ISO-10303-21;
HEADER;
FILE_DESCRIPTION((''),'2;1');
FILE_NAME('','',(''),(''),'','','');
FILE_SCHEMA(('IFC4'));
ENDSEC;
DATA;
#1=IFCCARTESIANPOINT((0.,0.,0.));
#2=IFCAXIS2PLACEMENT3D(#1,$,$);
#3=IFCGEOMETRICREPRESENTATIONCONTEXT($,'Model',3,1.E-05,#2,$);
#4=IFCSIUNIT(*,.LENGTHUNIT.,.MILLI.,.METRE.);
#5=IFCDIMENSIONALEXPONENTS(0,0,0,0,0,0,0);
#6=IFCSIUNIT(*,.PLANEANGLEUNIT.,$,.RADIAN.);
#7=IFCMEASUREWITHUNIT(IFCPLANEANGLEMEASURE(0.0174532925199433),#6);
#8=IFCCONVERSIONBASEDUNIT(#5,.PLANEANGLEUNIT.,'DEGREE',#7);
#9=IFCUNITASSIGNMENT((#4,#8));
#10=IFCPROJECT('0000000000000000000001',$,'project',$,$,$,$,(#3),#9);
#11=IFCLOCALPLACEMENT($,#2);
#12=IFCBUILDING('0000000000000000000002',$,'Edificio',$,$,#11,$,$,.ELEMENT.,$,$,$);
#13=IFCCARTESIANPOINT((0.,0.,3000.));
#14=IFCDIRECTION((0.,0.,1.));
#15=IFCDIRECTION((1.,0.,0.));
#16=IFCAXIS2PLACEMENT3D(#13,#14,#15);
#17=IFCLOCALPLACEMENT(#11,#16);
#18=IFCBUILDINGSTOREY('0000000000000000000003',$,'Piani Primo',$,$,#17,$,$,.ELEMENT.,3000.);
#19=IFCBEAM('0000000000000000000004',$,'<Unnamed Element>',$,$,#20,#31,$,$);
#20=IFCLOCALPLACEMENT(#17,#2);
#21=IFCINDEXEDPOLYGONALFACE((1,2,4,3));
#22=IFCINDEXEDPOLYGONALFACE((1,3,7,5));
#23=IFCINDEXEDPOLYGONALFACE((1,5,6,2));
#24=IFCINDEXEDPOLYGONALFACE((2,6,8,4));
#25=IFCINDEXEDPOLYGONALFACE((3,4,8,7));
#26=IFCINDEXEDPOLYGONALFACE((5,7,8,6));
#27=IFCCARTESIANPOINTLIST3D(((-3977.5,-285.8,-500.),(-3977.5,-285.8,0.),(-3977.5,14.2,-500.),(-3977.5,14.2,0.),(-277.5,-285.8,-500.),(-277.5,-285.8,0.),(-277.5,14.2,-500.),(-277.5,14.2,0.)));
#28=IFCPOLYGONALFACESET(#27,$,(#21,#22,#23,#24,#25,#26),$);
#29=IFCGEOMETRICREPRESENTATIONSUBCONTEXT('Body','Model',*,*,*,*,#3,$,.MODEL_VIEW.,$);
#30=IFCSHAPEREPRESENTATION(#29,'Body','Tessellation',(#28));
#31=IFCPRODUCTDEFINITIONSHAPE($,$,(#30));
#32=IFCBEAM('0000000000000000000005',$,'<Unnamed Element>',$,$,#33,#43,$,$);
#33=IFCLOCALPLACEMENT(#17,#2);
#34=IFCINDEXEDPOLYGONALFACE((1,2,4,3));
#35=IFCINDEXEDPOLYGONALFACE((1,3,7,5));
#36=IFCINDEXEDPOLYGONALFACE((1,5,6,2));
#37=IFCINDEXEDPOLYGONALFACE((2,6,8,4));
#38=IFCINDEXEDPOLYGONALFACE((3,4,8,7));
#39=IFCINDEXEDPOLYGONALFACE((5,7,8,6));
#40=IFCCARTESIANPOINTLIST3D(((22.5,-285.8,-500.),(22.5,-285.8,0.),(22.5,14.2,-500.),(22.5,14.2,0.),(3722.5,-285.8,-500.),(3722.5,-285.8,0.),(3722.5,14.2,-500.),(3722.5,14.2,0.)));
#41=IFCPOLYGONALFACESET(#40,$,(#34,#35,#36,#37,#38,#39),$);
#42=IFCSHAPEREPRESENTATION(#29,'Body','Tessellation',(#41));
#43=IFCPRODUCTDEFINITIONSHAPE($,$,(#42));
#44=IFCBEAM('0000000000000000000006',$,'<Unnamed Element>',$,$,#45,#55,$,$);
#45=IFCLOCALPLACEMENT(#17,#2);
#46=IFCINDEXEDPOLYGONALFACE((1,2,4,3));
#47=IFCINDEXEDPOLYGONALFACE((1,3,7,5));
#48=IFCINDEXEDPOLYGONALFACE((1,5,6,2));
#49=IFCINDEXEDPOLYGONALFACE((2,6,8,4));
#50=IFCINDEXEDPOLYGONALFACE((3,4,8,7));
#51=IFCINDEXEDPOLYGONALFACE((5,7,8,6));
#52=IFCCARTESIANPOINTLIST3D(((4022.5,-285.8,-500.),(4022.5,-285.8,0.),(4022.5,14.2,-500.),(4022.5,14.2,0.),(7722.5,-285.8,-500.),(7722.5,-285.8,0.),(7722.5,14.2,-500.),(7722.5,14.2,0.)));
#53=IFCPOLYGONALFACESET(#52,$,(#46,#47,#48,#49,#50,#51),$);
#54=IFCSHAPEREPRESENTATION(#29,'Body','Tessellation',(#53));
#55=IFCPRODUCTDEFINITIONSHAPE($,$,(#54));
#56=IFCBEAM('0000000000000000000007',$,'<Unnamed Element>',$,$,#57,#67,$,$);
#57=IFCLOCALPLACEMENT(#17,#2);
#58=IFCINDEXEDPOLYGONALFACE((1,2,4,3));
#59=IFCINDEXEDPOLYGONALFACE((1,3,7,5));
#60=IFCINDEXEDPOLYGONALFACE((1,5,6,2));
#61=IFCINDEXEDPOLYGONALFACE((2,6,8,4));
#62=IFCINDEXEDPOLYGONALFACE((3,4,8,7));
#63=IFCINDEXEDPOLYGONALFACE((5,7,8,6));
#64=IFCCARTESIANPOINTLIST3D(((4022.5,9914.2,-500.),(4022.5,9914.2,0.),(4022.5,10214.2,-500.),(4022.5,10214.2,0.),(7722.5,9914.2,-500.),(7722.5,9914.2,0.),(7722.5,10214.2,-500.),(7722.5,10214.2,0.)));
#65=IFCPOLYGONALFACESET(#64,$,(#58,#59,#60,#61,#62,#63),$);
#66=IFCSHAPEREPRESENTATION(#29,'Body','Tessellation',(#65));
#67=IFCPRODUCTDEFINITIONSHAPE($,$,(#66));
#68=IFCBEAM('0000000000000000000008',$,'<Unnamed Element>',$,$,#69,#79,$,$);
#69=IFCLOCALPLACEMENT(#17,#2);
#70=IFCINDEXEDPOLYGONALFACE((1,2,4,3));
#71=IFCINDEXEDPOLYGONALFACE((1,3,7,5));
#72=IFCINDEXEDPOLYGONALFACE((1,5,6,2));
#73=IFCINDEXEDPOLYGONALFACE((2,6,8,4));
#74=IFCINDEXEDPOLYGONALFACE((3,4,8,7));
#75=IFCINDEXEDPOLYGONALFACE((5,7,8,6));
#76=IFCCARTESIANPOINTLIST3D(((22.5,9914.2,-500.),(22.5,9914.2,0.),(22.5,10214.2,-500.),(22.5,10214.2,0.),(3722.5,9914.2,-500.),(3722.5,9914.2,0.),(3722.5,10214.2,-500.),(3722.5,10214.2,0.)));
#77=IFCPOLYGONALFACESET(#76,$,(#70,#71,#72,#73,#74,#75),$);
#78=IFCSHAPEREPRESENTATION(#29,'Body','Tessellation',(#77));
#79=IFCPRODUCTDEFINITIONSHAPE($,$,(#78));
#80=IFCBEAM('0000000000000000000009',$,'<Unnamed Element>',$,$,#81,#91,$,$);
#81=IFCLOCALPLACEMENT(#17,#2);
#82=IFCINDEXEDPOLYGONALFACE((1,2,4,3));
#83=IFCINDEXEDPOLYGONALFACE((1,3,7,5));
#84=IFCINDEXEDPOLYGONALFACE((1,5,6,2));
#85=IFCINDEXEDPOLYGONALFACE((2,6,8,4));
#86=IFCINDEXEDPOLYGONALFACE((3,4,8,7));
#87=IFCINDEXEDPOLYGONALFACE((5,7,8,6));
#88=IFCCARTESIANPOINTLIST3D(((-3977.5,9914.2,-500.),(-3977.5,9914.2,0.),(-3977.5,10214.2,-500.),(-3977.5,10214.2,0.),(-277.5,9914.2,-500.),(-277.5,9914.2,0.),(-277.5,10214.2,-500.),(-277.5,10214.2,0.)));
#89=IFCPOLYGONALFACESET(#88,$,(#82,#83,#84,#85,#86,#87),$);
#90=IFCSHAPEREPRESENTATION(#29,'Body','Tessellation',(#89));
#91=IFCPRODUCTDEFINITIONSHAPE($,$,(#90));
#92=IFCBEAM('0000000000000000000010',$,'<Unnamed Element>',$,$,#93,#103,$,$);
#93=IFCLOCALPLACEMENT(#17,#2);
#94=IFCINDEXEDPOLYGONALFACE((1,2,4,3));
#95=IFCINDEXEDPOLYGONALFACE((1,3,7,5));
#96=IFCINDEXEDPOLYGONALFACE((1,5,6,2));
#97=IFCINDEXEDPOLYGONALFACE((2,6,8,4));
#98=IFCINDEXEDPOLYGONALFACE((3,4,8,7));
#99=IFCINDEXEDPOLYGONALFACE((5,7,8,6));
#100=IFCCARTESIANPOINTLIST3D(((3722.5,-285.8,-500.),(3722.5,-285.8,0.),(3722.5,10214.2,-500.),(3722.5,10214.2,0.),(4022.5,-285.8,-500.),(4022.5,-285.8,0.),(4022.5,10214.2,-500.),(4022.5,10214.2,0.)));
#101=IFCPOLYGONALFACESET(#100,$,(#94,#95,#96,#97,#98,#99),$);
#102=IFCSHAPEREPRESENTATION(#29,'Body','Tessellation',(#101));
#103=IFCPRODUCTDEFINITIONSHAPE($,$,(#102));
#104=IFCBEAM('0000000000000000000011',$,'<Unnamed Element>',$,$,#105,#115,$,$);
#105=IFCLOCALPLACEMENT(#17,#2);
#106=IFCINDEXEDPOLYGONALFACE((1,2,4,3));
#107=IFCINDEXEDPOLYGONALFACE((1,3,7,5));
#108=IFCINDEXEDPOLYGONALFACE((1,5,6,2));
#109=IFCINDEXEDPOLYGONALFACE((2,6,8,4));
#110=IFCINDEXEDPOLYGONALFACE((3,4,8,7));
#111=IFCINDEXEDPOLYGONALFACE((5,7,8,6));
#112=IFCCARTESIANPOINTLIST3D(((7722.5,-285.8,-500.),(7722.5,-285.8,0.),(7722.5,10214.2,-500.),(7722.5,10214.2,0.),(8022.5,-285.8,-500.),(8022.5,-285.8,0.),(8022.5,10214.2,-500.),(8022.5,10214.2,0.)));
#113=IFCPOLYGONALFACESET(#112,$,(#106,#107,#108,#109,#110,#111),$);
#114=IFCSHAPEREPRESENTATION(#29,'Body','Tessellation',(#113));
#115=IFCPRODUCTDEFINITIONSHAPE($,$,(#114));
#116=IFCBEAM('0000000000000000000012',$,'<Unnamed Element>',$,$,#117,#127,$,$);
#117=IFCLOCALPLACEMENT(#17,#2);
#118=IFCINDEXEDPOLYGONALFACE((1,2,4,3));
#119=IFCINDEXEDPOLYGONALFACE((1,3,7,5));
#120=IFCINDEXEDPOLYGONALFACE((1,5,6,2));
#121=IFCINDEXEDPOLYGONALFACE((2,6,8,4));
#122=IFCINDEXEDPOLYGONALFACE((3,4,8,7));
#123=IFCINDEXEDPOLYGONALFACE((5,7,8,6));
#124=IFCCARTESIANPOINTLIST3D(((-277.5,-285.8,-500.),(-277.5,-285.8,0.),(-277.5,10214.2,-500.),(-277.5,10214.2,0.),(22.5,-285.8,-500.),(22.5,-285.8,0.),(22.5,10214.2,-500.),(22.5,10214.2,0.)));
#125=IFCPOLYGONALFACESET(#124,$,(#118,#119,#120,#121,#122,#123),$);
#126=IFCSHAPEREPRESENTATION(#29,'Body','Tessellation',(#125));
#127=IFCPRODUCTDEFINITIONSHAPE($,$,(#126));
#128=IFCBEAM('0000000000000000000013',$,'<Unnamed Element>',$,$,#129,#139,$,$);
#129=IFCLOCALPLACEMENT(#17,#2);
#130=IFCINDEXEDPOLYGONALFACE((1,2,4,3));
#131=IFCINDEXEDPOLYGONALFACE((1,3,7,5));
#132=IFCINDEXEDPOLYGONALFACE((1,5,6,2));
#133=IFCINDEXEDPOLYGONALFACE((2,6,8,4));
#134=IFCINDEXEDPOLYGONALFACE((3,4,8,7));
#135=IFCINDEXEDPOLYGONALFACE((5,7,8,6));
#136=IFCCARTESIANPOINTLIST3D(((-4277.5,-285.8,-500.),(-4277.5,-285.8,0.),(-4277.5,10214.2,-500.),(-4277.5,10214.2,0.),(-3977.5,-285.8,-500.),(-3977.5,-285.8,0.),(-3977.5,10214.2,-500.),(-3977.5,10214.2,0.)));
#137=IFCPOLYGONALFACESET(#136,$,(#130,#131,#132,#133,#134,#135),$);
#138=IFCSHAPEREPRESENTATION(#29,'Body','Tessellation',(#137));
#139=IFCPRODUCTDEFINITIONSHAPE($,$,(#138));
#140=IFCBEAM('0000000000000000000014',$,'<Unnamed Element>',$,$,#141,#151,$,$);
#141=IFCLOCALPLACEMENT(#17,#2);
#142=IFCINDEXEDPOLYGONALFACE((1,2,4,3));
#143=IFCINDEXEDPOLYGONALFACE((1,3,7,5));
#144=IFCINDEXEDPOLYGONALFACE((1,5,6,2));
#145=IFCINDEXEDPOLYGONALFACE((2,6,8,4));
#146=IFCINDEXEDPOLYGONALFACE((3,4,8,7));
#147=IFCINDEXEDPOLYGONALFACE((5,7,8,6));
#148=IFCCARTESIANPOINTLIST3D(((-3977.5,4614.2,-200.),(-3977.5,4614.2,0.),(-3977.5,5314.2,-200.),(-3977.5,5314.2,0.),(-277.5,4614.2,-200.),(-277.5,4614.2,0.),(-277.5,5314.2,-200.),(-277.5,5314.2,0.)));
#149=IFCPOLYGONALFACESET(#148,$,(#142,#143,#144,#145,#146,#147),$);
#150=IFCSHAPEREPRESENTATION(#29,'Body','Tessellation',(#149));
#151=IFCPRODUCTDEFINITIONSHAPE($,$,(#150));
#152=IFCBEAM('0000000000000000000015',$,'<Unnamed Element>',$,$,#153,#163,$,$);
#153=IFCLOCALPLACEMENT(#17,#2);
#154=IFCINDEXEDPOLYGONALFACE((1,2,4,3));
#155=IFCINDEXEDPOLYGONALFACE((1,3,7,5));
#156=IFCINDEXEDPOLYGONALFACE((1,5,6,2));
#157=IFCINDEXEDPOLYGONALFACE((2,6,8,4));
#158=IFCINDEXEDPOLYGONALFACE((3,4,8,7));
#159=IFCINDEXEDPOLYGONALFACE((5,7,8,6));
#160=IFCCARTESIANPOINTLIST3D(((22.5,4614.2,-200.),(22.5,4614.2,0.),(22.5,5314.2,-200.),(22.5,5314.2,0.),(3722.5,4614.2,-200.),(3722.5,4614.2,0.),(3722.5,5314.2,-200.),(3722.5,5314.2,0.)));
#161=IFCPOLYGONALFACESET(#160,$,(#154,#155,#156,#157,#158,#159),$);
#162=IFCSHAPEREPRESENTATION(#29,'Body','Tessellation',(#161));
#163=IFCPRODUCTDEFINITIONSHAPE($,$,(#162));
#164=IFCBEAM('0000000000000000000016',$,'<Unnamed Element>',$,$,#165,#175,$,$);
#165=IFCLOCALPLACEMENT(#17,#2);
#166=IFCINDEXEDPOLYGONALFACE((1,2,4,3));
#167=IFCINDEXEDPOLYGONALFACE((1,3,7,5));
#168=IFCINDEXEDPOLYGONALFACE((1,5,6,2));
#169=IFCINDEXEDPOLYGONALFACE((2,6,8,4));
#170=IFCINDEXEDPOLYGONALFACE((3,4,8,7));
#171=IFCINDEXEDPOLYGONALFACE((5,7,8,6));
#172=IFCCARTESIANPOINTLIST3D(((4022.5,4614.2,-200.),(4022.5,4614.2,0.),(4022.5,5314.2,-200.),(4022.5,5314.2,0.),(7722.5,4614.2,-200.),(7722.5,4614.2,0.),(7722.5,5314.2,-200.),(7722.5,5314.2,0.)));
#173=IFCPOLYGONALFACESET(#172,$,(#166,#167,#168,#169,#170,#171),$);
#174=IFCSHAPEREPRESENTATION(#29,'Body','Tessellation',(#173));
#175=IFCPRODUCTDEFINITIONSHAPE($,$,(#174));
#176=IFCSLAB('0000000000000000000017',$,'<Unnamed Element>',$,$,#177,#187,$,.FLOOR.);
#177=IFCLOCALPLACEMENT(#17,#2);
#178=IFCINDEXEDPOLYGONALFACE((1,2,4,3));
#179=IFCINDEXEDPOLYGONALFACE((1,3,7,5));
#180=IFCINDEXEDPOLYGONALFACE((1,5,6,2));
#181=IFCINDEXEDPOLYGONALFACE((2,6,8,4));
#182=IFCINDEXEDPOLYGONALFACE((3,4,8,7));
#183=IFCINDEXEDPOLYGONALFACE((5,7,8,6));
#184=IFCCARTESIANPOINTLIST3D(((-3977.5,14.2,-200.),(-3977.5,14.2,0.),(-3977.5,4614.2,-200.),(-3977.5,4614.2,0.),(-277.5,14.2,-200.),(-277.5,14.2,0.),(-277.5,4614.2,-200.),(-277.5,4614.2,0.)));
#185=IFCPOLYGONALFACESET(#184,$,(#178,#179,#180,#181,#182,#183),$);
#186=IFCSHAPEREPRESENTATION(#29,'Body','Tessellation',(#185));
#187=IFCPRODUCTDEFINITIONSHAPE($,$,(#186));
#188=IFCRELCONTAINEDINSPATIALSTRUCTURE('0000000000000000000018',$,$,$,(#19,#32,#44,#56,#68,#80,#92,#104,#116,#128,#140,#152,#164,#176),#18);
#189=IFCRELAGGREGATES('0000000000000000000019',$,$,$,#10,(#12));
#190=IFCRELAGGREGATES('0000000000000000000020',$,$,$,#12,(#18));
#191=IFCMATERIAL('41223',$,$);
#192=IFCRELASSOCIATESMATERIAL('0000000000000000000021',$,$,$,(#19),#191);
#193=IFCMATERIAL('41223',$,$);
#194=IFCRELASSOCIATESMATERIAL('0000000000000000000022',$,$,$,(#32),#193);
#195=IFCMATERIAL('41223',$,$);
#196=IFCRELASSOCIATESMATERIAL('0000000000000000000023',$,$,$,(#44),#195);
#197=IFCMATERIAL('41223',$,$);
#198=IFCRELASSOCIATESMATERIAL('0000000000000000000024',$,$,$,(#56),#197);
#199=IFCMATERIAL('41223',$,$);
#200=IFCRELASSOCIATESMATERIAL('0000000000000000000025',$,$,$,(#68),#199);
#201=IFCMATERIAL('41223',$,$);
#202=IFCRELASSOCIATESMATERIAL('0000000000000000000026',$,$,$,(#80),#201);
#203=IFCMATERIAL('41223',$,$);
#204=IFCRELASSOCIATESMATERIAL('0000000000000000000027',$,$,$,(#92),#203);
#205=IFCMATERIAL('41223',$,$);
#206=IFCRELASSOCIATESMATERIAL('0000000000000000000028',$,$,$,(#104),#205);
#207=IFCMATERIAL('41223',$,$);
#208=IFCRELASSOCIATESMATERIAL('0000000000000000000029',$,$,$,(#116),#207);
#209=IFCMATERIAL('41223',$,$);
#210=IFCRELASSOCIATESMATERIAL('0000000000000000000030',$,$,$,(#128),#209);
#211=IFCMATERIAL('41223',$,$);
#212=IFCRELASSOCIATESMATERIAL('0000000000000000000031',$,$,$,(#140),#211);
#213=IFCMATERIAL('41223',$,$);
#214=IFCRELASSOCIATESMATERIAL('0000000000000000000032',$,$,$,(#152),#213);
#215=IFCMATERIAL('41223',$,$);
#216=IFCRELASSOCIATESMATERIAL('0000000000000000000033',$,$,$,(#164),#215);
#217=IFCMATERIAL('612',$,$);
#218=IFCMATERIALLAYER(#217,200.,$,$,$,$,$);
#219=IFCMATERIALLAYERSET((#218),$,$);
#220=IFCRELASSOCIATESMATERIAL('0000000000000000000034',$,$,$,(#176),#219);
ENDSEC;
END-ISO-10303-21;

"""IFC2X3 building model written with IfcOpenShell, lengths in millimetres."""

from ifc_helpers import new_model, entity, si_unit, converted_unit, frame, frame_2d, origin, origin_with_axes, place, context, subcontext, project, spatial, rectangle, extrude, material, layer, layer_set, layer_usage, element, save


model = new_model("IFC2X3")

# Units and contexts
model_context = context("Model", 3, precision=1e-05, world=origin())
body_context = subcontext(model_context, "Body", "Model", "MODEL_VIEW")
ifc_project = project(units=[si_unit("LENGTHUNIT", "METRE", prefix="MILLI"), converted_unit("PLANEANGLEUNIT", "DEGREE", entity("IfcPlaneAngleMeasure", 0.0174532925199433), si_unit("PLANEANGLEUNIT", "RADIAN"), dimensions=[0, 0, 0, 0, 0, 0, 0])], contexts=[model_context])

# Building, storey
building_placement = place(None, origin())
building = spatial("IfcBuilding", under=ifc_project, at=building_placement, Name="Edificio", CompositionType="ELEMENT")
storey_placement = place(building_placement, frame((0.0, 0.0, 3000.0), z_axis=(0.0, 0.0, 1.0), x_axis=(1.0, 0.0, 0.0)))
storey = spatial("IfcBuildingStorey", under=building, at=storey_placement, Name="Piani Primo", CompositionType="ELEMENT", Elevation=3000.0)

# Beams
ifc_material_1 = material(Name="41223")
beam_1_placement = place(storey_placement, frame((-3977.5, -285.8, -500.0), z_axis=(0.0, 0.0, 1.0), x_axis=(1.0, 0.0, 0.0)))
element("IfcBeam", 1, at=beam_1_placement, inside=storey, material=ifc_material_1, Name="<Unnamed Element>", context=body_context, shape_type="SweptSolid", body=[
    extrude(rectangle(XDim=500.0, YDim=300.0, at=frame_2d((250.0, -150.0), x_axis=(1.0, 0.0))), frame((0.0, 0.0, 0.0), z_axis=(1.0, 0.0, 0.0), x_axis=(0.0, 0.0, 1.0)), (0.0, 0.0, 1.0), 3700.0),
])
ifc_material_2 = material(Name="41223")
beam_2_placement = place(storey_placement, frame((22.5, -285.8, -500.0), z_axis=(0.0, 0.0, 1.0), x_axis=(1.0, 0.0, 0.0)))
element("IfcBeam", 2, at=beam_2_placement, inside=storey, material=ifc_material_2, Name="<Unnamed Element>", context=body_context, shape_type="SweptSolid", body=[
    extrude(rectangle(XDim=500.0, YDim=300.0, at=frame_2d((250.0, -150.0), x_axis=(1.0, 0.0))), frame((0.0, 0.0, 0.0), z_axis=(1.0, 0.0, 0.0), x_axis=(0.0, 0.0, 1.0)), (0.0, 0.0, 1.0), 3700.0),
])
ifc_material_3 = material(Name="41223")
beam_3_placement = place(storey_placement, frame((4022.5, -285.8, -500.0), z_axis=(0.0, 0.0, 1.0), x_axis=(1.0, 0.0, 0.0)))
element("IfcBeam", 3, at=beam_3_placement, inside=storey, material=ifc_material_3, Name="<Unnamed Element>", context=body_context, shape_type="SweptSolid", body=[
    extrude(rectangle(XDim=500.0, YDim=300.0, at=frame_2d((250.0, -150.0), x_axis=(1.0, 0.0))), frame((0.0, 0.0, 0.0), z_axis=(1.0, 0.0, 0.0), x_axis=(0.0, 0.0, 1.0)), (0.0, 0.0, 1.0), 3700.0),
])
ifc_material_4 = material(Name="41223")
beam_4_placement = place(storey_placement, frame((7722.5, 10214.2, -500.0), z_axis=(0.0, 0.0, 1.0), x_axis=(-1.0, 0.0, 0.0)))
element("IfcBeam", 4, at=beam_4_placement, inside=storey, material=ifc_material_4, Name="<Unnamed Element>", context=body_context, shape_type="SweptSolid", body=[
    extrude(rectangle(XDim=500.0, YDim=300.0, at=frame_2d((250.0, -150.0), x_axis=(1.0, 0.0))), frame((0.0, 0.0, 0.0), z_axis=(1.0, 0.0, 0.0), x_axis=(0.0, 0.0, 1.0)), (0.0, 0.0, 1.0), 3700.0),
])
ifc_material_5 = material(Name="41223")
beam_5_placement = place(storey_placement, frame((3722.5, 10214.2, -500.0), z_axis=(0.0, 0.0, 1.0), x_axis=(-1.0, 0.0, 0.0)))
element("IfcBeam", 5, at=beam_5_placement, inside=storey, material=ifc_material_5, Name="<Unnamed Element>", context=body_context, shape_type="SweptSolid", body=[
    extrude(rectangle(XDim=500.0, YDim=300.0, at=frame_2d((250.0, -150.0), x_axis=(1.0, 0.0))), frame((0.0, 0.0, 0.0), z_axis=(1.0, 0.0, 0.0), x_axis=(0.0, 0.0, 1.0)), (0.0, 0.0, 1.0), 3700.0),
])
ifc_material_6 = material(Name="41223")
beam_6_placement = place(storey_placement, frame((-277.5, 10214.2, -500.0), z_axis=(0.0, 0.0, 1.0), x_axis=(-1.0, 0.0, 0.0)))
element("IfcBeam", 6, at=beam_6_placement, inside=storey, material=ifc_material_6, Name="<Unnamed Element>", context=body_context, shape_type="SweptSolid", body=[
    extrude(rectangle(XDim=500.0, YDim=300.0, at=frame_2d((250.0, -150.0), x_axis=(1.0, 0.0))), frame((0.0, 0.0, 0.0), z_axis=(1.0, 0.0, 0.0), x_axis=(0.0, 0.0, 1.0)), (0.0, 0.0, 1.0), 3700.0),
])
ifc_material_7 = material(Name="41223")
beam_7_placement = place(storey_placement, frame((4022.5, -285.8, -500.0), z_axis=(0.0, 0.0, 1.0), x_axis=(0.0, 1.0, 0.0)))
element("IfcBeam", 7, at=beam_7_placement, inside=storey, material=ifc_material_7, Name="<Unnamed Element>", context=body_context, shape_type="SweptSolid", body=[
    extrude(rectangle(XDim=500.0, YDim=300.0, at=frame_2d((250.0, -150.0), x_axis=(1.0, 0.0))), frame((0.0, 0.0, 0.0), z_axis=(1.0, 0.0, 0.0), x_axis=(0.0, 0.0, 1.0)), (0.0, 0.0, 1.0), 10500.0),
])
ifc_material_8 = material(Name="41223")
beam_8_placement = place(storey_placement, frame((8022.5, -285.8, -500.0), z_axis=(0.0, 0.0, 1.0), x_axis=(0.0, 1.0, 0.0)))
element("IfcBeam", 8, at=beam_8_placement, inside=storey, material=ifc_material_8, Name="<Unnamed Element>", context=body_context, shape_type="SweptSolid", body=[
    extrude(rectangle(XDim=500.0, YDim=300.0, at=frame_2d((250.0, -150.0), x_axis=(1.0, 0.0))), frame((0.0, 0.0, 0.0), z_axis=(1.0, 0.0, 0.0), x_axis=(0.0, 0.0, 1.0)), (0.0, 0.0, 1.0), 10500.0),
])
ifc_material_9 = material(Name="41223")
beam_9_placement = place(storey_placement, frame((22.5, -285.8, -500.0), z_axis=(0.0, 0.0, 1.0), x_axis=(0.0, 1.0, 0.0)))
element("IfcBeam", 9, at=beam_9_placement, inside=storey, material=ifc_material_9, Name="<Unnamed Element>", context=body_context, shape_type="SweptSolid", body=[
    extrude(rectangle(XDim=500.0, YDim=300.0, at=frame_2d((250.0, -150.0), x_axis=(1.0, 0.0))), frame((0.0, 0.0, 0.0), z_axis=(1.0, 0.0, 0.0), x_axis=(0.0, 0.0, 1.0)), (0.0, 0.0, 1.0), 10500.0),
])
ifc_material_10 = material(Name="41223")
beam_10_placement = place(storey_placement, frame((-3977.5, -285.8, -500.0), z_axis=(0.0, 0.0, 1.0), x_axis=(0.0, 1.0, 0.0)))
element("IfcBeam", 10, at=beam_10_placement, inside=storey, material=ifc_material_10, Name="<Unnamed Element>", context=body_context, shape_type="SweptSolid", body=[
    extrude(rectangle(XDim=500.0, YDim=300.0, at=frame_2d((250.0, -150.0), x_axis=(1.0, 0.0))), frame((0.0, 0.0, 0.0), z_axis=(1.0, 0.0, 0.0), x_axis=(0.0, 0.0, 1.0)), (0.0, 0.0, 1.0), 10500.0),
])
ifc_material_11 = material(Name="41223")
beam_11_placement = place(storey_placement, frame((-3977.5, 4614.2, -200.0), z_axis=(0.0, 0.0, 1.0), x_axis=(1.0, 0.0, 0.0)))
element("IfcBeam", 11, at=beam_11_placement, inside=storey, material=ifc_material_11, Name="<Unnamed Element>", context=body_context, shape_type="SweptSolid", body=[
    extrude(rectangle(XDim=200.0, YDim=700.0, at=frame_2d((100.0, -350.0), x_axis=(1.0, 0.0))), frame((0.0, 0.0, 0.0), z_axis=(1.0, 0.0, 0.0), x_axis=(0.0, 0.0, 1.0)), (0.0, 0.0, 1.0), 3700.0),
])
ifc_material_12 = material(Name="41223")
beam_12_placement = place(storey_placement, frame((22.5, 4614.2, -200.0), z_axis=(0.0, 0.0, 1.0), x_axis=(1.0, 0.0, 0.0)))
element("IfcBeam", 12, at=beam_12_placement, inside=storey, material=ifc_material_12, Name="<Unnamed Element>", context=body_context, shape_type="SweptSolid", body=[
    extrude(rectangle(XDim=200.0, YDim=700.0, at=frame_2d((100.0, -350.0), x_axis=(1.0, 0.0))), frame((0.0, 0.0, 0.0), z_axis=(1.0, 0.0, 0.0), x_axis=(0.0, 0.0, 1.0)), (0.0, 0.0, 1.0), 3700.0),
])
ifc_material_13 = material(Name="41223")
beam_13_placement = place(storey_placement, frame((4022.5, 4614.2, -200.0), z_axis=(0.0, 0.0, 1.0), x_axis=(1.0, 0.0, 0.0)))
element("IfcBeam", 13, at=beam_13_placement, inside=storey, material=ifc_material_13, Name="<Unnamed Element>", context=body_context, shape_type="SweptSolid", body=[
    extrude(rectangle(XDim=200.0, YDim=700.0, at=frame_2d((100.0, -350.0), x_axis=(1.0, 0.0))), frame((0.0, 0.0, 0.0), z_axis=(1.0, 0.0, 0.0), x_axis=(0.0, 0.0, 1.0)), (0.0, 0.0, 1.0), 3700.0),
])

# Slab
ifc_material_14 = material(Name="612")
ifc_layer_1 = layer(ifc_material_14, 200.0)
ifc_layer_set_1 = layer_set([ifc_layer_1])
ifc_layer_usage_1 = layer_usage(ifc_layer_set_1, "AXIS3", "POSITIVE", 0.0)
slab_1_placement = place(storey_placement, frame((-3977.5, 4614.2, -200.0), z_axis=(0.0, 0.0, 1.0), x_axis=(1.0, 0.0, 0.0)))
element("IfcSlab", 14, at=slab_1_placement, inside=storey, material=ifc_layer_usage_1, Name="<Unnamed Element>", PredefinedType="FLOOR", context=body_context, shape_type="SweptSolid", body=[
    extrude(rectangle(XDim=4600.0, YDim=3700.0, at=frame_2d((1850.0, -2300.0), x_axis=(0.0, -1.0))), origin_with_axes(), (0.0, 0.0, 1.0), 200.0),
])

save(model, "model.ifc")
